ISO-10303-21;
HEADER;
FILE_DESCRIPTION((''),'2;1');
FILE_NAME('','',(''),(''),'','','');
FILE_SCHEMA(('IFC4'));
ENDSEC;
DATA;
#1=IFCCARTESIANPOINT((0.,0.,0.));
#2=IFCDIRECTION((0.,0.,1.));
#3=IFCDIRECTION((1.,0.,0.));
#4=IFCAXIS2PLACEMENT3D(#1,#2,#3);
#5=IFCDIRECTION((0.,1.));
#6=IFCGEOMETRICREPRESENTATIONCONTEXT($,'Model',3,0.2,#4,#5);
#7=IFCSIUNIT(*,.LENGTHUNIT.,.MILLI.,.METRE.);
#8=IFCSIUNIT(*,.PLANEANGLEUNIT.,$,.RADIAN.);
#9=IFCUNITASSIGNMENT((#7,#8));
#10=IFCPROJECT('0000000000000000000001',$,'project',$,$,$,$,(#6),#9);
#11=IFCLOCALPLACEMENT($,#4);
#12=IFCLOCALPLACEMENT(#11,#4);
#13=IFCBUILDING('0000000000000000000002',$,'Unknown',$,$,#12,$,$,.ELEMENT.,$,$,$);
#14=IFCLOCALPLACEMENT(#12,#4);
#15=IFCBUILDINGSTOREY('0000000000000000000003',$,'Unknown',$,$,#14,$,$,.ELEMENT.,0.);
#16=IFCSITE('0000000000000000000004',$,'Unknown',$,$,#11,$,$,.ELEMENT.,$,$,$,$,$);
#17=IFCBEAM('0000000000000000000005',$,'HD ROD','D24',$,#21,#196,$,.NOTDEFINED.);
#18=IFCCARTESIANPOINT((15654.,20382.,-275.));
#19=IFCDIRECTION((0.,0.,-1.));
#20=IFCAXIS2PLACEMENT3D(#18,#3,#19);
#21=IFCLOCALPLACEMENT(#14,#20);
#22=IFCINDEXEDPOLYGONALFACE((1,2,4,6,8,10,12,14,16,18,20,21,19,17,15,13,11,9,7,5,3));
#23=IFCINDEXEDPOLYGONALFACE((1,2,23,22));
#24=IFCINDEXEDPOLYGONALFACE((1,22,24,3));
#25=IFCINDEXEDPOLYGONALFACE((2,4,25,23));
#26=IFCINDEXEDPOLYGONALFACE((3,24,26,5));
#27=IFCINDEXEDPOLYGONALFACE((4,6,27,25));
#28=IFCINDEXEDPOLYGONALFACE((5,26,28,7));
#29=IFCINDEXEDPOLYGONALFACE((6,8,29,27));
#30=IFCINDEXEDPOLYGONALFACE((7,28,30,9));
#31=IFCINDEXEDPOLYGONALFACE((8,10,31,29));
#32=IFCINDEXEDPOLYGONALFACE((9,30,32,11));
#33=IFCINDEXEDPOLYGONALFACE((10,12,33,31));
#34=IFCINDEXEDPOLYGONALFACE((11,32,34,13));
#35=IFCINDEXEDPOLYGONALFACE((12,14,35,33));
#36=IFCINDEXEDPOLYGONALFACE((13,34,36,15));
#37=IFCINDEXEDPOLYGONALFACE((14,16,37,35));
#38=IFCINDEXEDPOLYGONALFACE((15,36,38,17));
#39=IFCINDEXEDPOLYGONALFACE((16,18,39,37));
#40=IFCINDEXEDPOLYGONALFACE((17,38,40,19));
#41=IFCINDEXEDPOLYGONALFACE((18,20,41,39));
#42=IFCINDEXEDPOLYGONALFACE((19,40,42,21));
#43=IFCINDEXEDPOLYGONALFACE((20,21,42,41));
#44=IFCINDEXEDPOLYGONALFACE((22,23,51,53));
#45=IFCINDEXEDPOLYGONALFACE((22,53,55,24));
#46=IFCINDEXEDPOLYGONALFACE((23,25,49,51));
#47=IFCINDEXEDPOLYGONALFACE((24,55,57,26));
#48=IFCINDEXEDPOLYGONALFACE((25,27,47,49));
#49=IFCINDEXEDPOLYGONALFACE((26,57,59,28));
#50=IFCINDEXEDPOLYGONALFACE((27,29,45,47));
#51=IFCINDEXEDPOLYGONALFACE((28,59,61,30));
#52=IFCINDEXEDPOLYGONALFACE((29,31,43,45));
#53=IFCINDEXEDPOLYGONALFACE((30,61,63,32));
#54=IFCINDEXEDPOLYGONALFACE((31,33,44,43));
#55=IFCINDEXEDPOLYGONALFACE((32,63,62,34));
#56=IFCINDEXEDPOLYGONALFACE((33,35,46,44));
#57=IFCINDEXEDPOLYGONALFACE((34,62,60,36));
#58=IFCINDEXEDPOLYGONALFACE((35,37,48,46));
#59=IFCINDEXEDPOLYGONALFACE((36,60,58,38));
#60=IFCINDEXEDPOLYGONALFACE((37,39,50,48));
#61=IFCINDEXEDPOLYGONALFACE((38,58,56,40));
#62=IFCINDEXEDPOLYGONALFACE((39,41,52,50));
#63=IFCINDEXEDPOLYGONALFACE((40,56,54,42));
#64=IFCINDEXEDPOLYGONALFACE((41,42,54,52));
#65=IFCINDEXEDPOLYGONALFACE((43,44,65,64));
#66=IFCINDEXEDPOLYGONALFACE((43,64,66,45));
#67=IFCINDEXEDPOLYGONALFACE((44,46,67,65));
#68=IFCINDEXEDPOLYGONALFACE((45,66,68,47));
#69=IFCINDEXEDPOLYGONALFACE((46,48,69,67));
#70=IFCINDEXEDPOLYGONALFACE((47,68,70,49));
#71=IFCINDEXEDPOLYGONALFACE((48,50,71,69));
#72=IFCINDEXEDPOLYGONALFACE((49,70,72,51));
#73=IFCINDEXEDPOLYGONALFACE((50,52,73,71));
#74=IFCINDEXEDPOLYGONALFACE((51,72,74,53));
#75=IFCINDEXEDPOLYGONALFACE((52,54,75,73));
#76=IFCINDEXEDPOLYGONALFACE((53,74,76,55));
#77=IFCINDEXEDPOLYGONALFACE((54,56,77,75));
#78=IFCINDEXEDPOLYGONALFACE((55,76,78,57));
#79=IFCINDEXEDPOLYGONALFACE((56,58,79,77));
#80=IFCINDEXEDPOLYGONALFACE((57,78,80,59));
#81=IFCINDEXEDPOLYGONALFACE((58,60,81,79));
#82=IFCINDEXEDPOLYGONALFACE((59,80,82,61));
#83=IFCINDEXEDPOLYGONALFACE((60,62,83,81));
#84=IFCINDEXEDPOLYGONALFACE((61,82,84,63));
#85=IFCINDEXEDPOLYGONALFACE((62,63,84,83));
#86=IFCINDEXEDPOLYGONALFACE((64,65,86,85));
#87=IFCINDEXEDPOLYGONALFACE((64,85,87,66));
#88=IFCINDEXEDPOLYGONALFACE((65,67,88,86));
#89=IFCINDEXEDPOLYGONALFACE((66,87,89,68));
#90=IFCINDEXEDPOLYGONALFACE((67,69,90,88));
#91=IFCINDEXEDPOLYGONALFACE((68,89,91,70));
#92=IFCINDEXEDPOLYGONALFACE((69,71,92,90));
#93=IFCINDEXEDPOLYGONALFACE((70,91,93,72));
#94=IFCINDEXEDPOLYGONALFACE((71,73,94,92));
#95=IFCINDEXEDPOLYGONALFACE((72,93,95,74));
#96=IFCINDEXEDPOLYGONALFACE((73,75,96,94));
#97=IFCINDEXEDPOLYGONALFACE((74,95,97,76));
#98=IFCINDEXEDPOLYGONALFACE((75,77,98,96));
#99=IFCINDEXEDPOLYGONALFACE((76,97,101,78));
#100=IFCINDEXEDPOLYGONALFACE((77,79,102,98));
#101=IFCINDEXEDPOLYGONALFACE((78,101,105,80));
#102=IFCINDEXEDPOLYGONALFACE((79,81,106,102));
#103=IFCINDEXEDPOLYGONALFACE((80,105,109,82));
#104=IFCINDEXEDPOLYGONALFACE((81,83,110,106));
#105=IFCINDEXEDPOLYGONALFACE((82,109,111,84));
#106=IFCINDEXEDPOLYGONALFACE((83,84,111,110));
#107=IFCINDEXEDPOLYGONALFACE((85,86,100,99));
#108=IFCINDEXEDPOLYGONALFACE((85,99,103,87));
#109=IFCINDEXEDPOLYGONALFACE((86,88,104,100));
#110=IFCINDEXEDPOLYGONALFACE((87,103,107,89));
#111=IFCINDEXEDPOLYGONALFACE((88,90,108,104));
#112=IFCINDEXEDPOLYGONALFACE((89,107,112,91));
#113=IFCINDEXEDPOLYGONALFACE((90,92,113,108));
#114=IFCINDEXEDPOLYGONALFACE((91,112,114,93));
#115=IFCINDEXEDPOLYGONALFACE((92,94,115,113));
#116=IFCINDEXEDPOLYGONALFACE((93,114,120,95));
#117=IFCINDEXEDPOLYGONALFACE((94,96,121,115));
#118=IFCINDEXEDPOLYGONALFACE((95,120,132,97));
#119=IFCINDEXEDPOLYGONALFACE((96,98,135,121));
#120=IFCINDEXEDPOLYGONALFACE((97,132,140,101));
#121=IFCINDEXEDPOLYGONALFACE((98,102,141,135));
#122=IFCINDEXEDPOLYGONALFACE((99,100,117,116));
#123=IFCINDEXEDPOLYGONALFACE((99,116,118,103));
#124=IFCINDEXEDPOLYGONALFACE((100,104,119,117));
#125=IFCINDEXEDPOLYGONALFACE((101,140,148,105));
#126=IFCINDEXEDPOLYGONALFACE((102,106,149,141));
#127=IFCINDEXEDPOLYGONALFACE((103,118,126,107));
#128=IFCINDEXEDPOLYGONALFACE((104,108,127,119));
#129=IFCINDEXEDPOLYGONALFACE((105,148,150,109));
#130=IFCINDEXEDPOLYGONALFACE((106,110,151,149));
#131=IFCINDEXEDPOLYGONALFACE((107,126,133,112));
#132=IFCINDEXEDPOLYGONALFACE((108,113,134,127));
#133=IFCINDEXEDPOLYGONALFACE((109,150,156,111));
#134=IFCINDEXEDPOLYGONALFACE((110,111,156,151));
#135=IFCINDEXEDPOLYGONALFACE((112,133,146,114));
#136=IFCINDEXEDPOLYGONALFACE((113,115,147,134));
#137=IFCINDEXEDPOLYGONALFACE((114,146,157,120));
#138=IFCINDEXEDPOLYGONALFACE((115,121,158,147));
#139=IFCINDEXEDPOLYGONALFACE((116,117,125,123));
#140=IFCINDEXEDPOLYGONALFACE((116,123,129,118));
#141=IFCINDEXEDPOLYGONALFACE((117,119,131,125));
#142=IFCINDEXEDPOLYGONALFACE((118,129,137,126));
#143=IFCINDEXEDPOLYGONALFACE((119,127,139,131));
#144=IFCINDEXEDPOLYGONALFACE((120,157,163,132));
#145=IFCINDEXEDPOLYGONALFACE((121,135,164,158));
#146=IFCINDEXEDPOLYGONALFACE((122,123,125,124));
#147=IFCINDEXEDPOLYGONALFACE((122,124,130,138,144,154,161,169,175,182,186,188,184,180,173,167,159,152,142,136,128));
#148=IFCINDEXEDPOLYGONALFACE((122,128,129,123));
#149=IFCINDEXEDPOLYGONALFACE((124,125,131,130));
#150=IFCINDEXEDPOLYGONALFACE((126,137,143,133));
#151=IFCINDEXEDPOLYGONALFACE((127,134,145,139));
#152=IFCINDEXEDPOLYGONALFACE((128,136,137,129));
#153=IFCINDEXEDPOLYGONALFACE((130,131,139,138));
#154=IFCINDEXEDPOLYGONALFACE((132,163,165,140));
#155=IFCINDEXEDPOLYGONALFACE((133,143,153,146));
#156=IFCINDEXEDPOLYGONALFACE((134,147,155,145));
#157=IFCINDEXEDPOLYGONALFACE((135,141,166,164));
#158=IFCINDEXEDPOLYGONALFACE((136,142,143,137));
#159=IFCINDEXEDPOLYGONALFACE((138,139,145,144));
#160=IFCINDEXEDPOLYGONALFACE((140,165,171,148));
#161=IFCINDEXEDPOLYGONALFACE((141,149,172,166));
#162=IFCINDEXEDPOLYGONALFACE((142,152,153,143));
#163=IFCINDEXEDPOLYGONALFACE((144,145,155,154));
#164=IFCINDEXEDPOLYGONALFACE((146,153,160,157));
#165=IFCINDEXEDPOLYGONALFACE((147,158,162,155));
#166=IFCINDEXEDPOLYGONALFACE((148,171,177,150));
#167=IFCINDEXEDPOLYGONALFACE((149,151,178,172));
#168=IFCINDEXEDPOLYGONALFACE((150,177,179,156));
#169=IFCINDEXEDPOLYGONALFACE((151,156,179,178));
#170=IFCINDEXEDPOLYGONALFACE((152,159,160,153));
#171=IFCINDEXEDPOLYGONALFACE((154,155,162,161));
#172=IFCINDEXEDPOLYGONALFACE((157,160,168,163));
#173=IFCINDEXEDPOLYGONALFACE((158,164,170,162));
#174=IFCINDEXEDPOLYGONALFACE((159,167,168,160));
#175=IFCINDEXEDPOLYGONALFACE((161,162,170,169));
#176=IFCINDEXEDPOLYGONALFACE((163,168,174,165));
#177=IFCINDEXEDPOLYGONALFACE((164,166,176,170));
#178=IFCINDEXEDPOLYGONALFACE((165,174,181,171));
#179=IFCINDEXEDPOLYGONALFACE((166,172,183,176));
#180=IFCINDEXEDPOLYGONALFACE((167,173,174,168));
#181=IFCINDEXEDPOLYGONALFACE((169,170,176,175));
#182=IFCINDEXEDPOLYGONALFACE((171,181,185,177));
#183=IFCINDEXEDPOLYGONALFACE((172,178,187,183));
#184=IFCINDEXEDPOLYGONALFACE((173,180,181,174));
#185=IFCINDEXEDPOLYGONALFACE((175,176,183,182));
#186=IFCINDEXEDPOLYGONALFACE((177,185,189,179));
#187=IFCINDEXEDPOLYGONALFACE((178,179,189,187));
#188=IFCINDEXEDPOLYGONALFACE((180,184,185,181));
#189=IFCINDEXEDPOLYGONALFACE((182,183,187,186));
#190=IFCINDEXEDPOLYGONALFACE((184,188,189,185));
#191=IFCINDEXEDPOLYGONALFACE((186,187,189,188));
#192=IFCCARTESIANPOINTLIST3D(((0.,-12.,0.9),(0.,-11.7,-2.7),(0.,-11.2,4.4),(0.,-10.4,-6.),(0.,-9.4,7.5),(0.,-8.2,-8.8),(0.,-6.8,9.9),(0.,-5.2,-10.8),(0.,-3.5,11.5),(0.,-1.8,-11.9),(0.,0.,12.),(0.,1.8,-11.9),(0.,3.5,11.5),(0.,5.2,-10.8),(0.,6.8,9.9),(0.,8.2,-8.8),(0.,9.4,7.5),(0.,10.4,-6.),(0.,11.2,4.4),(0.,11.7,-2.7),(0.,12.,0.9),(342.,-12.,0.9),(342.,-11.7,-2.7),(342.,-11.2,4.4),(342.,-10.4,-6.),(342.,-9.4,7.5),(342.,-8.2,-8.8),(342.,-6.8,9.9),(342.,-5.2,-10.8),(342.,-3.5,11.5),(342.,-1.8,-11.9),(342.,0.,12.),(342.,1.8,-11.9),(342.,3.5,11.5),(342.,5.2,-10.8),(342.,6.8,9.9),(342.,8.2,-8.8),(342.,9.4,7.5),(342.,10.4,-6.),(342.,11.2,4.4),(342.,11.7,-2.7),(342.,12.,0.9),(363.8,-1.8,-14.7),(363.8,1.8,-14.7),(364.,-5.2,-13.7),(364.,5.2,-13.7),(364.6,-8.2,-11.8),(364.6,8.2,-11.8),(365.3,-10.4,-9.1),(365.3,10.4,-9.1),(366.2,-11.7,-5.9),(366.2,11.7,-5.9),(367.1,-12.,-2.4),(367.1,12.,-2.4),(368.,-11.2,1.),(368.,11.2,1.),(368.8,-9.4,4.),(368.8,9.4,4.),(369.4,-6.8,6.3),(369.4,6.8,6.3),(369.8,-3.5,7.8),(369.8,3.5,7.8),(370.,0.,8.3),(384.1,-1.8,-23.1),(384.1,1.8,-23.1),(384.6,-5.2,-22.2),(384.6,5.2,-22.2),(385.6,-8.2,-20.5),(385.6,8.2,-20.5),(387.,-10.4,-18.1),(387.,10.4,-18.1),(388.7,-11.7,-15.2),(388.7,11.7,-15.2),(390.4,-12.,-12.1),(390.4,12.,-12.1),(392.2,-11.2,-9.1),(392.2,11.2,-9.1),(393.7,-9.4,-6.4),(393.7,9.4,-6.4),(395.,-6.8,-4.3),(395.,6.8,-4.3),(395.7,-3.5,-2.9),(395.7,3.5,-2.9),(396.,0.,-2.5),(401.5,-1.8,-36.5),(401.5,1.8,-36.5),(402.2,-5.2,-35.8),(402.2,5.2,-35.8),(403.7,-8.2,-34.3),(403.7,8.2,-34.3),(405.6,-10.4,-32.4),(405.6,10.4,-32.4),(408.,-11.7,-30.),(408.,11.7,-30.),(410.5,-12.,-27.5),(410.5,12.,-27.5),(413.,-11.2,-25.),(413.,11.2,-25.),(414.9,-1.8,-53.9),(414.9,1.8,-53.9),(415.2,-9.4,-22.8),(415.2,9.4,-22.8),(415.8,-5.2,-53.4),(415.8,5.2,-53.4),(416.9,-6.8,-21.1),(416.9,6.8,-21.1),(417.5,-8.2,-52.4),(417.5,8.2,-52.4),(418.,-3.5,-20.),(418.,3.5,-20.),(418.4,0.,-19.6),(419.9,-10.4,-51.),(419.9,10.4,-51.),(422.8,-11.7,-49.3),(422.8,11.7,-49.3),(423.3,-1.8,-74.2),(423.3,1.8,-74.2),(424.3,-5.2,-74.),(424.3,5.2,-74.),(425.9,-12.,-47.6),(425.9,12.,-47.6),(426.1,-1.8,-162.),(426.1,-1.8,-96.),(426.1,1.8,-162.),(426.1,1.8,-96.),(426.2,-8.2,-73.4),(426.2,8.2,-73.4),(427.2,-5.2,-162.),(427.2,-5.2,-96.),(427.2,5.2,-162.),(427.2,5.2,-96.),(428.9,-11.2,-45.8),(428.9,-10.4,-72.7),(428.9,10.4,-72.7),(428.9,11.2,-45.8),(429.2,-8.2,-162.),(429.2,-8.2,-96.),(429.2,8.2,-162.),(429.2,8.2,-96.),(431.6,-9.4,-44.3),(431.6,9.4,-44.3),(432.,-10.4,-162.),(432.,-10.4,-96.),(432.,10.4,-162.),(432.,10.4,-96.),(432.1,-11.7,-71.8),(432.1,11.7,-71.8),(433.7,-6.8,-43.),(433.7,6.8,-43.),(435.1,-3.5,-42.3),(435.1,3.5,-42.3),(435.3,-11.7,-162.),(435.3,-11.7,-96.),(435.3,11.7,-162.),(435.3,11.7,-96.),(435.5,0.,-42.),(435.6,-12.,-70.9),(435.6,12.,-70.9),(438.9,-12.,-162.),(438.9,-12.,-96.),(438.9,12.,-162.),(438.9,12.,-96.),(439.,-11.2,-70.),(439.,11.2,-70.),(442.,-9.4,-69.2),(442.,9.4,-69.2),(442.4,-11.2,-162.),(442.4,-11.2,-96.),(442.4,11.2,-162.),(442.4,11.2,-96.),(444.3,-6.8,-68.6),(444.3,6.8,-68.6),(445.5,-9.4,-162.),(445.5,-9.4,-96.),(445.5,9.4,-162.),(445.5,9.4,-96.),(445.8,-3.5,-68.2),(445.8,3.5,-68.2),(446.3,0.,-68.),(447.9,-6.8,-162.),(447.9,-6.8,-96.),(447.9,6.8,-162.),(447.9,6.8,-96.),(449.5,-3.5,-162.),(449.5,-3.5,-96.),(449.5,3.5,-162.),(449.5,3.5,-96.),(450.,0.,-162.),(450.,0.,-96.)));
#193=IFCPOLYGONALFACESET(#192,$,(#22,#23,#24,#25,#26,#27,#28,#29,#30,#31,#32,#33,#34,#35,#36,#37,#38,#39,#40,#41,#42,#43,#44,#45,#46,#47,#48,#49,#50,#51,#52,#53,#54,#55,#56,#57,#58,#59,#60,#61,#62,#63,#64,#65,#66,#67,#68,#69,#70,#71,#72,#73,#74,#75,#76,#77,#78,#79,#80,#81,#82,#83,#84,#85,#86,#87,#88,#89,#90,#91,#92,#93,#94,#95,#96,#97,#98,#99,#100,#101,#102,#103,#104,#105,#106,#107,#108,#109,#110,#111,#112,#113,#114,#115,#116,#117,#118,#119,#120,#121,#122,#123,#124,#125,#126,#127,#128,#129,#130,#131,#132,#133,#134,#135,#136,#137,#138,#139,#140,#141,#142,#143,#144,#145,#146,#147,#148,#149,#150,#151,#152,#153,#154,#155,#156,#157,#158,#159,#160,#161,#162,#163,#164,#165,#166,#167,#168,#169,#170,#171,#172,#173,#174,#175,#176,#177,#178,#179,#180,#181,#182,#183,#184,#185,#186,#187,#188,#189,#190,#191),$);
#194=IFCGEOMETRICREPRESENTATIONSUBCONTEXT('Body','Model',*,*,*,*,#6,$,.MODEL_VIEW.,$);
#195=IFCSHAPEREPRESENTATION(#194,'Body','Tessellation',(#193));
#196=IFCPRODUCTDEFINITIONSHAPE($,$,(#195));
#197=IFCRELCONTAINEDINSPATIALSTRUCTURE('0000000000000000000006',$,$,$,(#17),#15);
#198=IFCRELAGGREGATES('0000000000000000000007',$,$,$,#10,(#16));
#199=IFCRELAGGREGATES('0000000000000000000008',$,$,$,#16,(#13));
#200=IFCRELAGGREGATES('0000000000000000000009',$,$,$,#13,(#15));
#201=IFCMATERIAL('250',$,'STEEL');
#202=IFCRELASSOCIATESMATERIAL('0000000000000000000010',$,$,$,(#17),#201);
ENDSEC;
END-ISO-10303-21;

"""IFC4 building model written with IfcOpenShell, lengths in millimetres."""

from ifc_helpers import new_model, entity, si_unit, direction, frame, origin_with_axes, place, context, subcontext, project, spatial, material, element, save


model = new_model("IFC4")

# Units and contexts
model_context = context("Model", 3, precision=0.2, world=origin_with_axes(), true_north=direction((0.0, 1.0)))
body_context = subcontext(model_context, "Body", "Model", "MODEL_VIEW")
ifc_project = project(units=[si_unit("LENGTHUNIT", "METRE", prefix="MILLI"), si_unit("PLANEANGLEUNIT", "RADIAN")], contexts=[model_context])

# Site, building, storey
site_placement = place(None, origin_with_axes())
site = spatial("IfcSite", under=ifc_project, at=site_placement, Name="Unknown", CompositionType="ELEMENT")
building_placement = place(site_placement, origin_with_axes())
building = spatial("IfcBuilding", under=site, at=building_placement, Name="Unknown", CompositionType="ELEMENT")
storey_placement = place(building_placement, origin_with_axes())
storey = spatial("IfcBuildingStorey", under=building, at=storey_placement, Name="Unknown", CompositionType="ELEMENT", Elevation=0.0)

# Shared definitions
ifc_material_1 = material(Name="250", Category="STEEL")

# Beam
beam_1_placement = place(storey_placement, frame((15654.0, 20382.0, -275.0), z_axis=(1.0, 0.0, 0.0), x_axis=(0.0, 0.0, -1.0)))
element("IfcBeam", 1, at=beam_1_placement, inside=storey, material=ifc_material_1, Name="HD ROD", Description="D24", PredefinedType="NOTDEFINED", context=body_context, shape_type="SolidModel", body=[
    entity("IfcSweptDiskSolid", entity("IfcIndexedPolyCurve", entity("IfcCartesianPointList3D", [[0.0, 0.0, 0.0], [342.0, 0.0, 0.0], [409.9, 0.0, -28.1], [438.0, 0.0, -96.0], [438.0, 0.0, -162.0]]), [entity("IfcLineIndex", [1, 2]), entity("IfcArcIndex", [2, 3, 4]), entity("IfcLineIndex", [4, 5])]), 12.0),
])

save(model, "model.ifc")
